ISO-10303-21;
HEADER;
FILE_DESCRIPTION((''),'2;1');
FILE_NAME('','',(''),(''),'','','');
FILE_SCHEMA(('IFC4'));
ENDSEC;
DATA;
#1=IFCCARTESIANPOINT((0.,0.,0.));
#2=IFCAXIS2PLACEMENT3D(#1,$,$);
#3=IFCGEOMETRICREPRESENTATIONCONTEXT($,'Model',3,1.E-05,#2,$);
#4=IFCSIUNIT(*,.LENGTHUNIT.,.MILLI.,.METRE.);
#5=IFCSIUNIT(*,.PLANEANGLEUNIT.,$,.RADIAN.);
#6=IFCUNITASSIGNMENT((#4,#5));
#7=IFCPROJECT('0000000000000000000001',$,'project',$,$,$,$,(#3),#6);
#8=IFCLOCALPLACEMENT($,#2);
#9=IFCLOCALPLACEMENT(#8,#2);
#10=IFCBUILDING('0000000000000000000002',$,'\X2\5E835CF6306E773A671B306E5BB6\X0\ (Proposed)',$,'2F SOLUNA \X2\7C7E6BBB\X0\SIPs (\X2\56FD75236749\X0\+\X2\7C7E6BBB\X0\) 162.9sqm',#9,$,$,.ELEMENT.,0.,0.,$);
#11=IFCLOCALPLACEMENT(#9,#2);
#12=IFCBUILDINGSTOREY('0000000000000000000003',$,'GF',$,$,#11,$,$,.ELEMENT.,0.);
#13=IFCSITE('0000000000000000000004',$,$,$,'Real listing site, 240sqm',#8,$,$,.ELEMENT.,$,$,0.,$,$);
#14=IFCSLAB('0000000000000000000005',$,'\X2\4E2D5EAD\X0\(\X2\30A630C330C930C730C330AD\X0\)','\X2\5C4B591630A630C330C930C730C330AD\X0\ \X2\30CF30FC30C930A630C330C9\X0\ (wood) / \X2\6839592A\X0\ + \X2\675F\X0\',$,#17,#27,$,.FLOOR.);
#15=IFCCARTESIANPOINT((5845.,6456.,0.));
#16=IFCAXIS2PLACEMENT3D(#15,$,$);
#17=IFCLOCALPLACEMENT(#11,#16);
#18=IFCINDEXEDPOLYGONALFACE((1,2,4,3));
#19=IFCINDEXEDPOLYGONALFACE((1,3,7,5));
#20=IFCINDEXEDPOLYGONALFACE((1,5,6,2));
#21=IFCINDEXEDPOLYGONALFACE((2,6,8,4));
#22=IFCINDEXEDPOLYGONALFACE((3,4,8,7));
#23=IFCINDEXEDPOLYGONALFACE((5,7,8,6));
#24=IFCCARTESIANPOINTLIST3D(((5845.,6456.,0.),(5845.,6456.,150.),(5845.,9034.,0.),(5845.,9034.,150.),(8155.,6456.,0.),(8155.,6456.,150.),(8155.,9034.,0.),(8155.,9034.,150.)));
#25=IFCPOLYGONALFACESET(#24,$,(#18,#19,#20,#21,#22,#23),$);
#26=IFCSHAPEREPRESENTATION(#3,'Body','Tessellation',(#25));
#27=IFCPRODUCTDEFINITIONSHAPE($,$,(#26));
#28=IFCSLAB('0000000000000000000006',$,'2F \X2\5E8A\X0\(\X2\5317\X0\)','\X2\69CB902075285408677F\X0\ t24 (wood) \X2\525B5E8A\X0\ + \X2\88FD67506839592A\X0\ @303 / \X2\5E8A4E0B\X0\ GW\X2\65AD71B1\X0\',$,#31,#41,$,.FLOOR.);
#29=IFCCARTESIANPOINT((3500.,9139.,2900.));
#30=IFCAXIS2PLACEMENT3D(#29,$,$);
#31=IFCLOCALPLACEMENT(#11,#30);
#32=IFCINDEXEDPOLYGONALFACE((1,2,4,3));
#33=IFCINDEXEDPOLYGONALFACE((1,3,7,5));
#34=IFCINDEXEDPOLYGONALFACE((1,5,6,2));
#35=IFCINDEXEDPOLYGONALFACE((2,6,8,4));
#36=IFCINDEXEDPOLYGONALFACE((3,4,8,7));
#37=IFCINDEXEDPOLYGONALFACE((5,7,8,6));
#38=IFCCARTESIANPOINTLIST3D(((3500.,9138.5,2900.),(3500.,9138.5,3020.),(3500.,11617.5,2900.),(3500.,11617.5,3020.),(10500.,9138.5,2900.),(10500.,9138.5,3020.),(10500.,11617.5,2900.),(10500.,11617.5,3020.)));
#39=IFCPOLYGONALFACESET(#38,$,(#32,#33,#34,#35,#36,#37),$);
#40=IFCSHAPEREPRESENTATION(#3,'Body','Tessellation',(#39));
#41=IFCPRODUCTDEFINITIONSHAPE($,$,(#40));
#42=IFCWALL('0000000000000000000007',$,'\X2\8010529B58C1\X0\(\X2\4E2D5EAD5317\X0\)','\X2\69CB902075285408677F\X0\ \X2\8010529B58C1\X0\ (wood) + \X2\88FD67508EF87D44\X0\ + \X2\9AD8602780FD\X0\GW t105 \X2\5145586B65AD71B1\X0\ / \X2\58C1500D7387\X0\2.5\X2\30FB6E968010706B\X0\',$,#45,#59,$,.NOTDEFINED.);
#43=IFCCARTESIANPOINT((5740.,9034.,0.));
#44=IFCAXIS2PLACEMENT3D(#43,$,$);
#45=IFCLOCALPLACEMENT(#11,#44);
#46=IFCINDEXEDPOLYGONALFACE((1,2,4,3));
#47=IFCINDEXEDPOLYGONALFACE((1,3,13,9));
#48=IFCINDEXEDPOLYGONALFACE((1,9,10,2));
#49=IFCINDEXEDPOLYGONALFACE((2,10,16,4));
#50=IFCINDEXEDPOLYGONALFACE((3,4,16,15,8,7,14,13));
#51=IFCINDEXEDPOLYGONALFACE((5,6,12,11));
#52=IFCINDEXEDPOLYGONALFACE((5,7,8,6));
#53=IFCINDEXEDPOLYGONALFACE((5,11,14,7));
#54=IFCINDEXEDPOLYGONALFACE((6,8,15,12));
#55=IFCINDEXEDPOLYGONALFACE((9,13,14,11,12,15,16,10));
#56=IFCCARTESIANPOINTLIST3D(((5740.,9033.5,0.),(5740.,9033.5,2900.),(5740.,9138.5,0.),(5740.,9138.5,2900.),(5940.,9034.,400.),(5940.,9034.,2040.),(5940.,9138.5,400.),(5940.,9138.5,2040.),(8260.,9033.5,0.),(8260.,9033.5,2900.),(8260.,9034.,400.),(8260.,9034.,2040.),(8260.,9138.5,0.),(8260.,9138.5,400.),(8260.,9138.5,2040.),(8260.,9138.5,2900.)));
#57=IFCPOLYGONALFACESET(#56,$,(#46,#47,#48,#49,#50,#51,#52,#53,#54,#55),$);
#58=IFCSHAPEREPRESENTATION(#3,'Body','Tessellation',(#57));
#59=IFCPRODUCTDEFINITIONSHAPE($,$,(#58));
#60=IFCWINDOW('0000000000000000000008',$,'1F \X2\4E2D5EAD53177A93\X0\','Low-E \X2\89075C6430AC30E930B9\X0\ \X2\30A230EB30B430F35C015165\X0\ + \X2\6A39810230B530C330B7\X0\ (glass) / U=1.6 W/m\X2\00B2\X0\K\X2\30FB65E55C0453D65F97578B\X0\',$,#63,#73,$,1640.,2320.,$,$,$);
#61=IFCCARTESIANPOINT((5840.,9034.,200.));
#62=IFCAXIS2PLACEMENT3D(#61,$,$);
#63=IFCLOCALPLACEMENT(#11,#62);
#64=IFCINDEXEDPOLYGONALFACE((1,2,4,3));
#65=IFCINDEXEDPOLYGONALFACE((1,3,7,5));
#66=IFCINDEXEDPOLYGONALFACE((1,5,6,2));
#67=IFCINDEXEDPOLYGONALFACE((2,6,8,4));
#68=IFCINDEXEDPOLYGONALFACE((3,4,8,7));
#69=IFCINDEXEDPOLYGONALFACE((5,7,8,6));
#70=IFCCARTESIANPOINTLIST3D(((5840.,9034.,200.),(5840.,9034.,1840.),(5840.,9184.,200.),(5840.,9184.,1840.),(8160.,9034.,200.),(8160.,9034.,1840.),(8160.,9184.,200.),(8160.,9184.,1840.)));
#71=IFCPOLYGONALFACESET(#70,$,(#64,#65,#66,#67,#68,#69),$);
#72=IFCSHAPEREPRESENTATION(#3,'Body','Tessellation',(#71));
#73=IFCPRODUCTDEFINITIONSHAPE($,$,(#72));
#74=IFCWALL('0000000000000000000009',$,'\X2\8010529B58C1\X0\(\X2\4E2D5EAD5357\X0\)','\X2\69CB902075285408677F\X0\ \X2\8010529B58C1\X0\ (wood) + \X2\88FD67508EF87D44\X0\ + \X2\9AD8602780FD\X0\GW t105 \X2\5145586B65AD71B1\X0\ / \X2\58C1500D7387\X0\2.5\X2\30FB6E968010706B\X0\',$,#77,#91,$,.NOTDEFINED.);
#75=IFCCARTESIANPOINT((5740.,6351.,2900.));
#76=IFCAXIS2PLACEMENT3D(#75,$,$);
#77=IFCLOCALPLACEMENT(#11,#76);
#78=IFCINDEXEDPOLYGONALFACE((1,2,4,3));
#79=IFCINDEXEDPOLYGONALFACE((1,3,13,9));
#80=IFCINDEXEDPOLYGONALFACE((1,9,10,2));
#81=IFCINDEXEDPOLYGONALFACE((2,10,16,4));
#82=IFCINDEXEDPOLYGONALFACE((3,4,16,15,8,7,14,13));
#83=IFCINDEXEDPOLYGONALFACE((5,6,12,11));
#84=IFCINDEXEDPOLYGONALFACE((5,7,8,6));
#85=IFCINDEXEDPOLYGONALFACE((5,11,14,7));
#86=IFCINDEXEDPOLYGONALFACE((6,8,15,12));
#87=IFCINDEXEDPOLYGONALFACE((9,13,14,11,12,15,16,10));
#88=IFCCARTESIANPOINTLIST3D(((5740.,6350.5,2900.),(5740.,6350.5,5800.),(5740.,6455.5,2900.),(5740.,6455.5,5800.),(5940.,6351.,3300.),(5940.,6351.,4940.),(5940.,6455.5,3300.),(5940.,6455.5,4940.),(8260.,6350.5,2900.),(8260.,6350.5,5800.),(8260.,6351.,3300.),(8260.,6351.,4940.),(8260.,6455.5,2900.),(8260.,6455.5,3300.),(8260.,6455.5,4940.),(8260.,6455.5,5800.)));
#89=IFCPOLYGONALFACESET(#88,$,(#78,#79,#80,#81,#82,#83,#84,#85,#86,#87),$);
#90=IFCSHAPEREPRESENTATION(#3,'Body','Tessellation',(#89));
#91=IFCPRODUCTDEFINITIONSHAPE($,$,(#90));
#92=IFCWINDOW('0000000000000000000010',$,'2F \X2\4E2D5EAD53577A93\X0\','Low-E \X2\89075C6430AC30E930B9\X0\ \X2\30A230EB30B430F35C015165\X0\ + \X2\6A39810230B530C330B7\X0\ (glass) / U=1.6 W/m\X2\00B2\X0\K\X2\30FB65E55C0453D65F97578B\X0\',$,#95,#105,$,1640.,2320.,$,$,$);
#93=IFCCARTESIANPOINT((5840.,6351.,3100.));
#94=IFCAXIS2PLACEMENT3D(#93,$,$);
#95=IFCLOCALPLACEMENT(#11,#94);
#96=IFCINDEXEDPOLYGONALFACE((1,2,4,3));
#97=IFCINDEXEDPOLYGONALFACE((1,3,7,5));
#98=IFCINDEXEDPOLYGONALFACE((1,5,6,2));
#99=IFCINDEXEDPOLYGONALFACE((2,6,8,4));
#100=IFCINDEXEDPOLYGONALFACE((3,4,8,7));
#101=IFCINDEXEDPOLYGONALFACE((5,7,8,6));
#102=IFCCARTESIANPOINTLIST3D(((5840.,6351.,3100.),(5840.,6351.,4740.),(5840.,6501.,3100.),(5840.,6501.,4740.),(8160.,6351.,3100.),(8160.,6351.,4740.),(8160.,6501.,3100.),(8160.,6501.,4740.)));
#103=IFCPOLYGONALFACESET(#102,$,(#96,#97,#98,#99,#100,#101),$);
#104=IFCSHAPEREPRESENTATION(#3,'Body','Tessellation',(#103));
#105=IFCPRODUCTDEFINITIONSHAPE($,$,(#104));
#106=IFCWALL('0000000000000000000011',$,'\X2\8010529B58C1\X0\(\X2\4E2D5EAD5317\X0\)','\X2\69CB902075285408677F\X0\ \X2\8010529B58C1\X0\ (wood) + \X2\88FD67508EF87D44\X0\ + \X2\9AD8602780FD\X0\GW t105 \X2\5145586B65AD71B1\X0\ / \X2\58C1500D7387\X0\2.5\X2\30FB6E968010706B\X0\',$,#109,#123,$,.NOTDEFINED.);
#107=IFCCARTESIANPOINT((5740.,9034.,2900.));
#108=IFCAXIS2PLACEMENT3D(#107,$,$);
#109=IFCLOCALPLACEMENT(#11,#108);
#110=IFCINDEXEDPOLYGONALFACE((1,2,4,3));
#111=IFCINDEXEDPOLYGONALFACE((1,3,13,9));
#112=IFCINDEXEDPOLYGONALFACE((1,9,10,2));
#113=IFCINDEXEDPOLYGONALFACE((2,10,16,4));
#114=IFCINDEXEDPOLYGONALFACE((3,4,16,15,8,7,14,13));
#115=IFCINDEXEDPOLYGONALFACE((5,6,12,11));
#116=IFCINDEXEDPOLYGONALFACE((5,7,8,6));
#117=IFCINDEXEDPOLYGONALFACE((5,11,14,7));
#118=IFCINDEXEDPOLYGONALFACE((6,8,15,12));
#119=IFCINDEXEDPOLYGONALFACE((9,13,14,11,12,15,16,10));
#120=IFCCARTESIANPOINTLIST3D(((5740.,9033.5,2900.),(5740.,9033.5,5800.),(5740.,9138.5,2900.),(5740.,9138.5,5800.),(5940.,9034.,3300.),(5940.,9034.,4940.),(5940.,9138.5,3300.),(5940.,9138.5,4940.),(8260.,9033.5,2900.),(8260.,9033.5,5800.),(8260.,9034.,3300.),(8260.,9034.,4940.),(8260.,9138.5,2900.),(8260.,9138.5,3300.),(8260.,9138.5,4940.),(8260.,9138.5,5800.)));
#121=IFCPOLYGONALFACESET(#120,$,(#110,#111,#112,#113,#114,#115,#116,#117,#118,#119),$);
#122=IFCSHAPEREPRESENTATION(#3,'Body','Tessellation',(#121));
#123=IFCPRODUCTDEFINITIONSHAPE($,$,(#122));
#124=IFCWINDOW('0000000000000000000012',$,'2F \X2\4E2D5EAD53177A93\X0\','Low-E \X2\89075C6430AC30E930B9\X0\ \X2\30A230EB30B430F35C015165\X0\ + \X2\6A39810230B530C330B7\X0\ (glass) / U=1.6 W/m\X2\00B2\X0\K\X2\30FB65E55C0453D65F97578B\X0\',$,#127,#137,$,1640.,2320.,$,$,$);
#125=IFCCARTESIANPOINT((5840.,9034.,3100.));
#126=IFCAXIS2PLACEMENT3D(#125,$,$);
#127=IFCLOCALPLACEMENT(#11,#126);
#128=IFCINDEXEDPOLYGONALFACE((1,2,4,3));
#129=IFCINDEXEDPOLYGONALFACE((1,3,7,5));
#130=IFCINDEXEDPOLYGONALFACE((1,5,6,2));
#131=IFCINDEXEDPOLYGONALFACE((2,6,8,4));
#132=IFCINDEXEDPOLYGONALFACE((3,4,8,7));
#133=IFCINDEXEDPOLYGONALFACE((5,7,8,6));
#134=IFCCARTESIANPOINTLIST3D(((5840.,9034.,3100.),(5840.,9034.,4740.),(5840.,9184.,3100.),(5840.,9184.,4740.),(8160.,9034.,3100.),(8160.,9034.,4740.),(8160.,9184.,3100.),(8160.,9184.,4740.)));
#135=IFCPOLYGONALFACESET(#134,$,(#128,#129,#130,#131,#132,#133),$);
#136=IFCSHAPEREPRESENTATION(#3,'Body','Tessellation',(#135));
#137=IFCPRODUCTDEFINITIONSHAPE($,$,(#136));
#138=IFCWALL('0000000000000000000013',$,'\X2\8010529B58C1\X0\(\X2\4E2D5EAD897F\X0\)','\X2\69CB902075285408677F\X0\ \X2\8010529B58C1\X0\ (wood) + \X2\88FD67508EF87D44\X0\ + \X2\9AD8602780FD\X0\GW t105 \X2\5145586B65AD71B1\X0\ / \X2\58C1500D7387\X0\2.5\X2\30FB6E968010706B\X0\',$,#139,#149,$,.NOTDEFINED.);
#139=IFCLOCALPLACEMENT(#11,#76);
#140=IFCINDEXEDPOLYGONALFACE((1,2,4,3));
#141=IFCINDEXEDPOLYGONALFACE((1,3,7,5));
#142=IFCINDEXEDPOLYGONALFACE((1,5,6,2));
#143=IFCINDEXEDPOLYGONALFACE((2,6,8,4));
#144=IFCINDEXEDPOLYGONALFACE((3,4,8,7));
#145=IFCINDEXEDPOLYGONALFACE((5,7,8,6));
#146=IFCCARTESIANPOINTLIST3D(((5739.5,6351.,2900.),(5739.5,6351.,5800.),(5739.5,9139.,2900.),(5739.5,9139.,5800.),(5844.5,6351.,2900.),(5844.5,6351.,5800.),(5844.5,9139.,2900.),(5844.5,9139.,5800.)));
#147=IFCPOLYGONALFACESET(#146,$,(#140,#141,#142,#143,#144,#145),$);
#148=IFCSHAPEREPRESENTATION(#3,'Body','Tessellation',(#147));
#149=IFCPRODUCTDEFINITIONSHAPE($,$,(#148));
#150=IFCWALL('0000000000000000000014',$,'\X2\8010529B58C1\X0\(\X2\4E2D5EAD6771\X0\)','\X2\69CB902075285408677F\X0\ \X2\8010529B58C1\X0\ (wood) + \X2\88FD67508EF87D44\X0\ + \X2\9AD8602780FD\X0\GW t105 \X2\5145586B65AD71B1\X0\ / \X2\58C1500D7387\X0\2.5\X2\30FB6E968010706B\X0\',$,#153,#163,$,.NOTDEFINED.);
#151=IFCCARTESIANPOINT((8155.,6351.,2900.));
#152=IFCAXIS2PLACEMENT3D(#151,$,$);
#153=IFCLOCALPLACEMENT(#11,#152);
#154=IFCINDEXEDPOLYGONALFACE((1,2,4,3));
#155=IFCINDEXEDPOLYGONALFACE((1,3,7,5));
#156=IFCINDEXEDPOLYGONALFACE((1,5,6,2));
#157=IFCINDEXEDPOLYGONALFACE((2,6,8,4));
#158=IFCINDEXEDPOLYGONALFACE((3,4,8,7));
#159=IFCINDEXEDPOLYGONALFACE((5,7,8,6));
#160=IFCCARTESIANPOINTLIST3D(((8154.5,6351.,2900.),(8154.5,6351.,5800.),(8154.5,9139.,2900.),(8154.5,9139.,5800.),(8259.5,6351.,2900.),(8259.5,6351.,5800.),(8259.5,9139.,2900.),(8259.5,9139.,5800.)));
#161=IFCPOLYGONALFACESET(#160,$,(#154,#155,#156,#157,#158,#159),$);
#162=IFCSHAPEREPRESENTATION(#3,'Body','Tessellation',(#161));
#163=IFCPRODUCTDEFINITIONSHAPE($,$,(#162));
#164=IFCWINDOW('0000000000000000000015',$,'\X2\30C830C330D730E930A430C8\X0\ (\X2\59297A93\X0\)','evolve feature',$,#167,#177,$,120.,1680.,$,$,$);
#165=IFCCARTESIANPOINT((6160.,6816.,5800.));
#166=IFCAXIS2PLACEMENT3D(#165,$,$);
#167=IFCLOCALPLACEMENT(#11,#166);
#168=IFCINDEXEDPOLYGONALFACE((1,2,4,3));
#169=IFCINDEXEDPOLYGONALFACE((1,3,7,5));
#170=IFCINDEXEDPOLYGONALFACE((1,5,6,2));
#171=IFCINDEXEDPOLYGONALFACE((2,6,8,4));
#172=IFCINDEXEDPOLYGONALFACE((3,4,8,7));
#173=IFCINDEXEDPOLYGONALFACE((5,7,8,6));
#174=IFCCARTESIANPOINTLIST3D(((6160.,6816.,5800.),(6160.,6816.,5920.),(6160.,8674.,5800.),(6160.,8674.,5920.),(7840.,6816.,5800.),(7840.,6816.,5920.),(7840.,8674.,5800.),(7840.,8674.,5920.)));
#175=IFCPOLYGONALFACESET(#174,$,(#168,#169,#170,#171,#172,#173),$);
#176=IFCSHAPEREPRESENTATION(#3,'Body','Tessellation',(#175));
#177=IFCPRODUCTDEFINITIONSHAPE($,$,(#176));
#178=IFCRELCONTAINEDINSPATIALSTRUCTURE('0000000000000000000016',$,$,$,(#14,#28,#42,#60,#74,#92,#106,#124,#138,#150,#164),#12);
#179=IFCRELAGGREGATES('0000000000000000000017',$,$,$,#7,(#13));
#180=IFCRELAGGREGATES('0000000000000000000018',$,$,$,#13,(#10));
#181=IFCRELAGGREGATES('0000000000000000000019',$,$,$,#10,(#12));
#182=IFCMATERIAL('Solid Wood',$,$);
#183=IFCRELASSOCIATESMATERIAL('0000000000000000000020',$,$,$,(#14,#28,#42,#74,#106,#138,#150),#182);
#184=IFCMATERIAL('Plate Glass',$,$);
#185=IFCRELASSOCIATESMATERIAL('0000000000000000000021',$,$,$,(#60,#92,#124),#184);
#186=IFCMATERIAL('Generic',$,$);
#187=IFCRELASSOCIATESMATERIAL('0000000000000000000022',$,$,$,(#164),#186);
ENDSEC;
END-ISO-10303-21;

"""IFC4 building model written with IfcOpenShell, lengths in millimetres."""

from ifc_helpers import new_model, si_unit, frame, frame_2d, origin, place, context, project, spatial, rectangle, extrude, material, element, fill, save


model = new_model("IFC4")

# Units and contexts
model_context = context("Model", 3, precision=1e-05, world=origin())
ifc_project = project(units=[si_unit("LENGTHUNIT", "METRE", prefix="MILLI"), si_unit("PLANEANGLEUNIT", "RADIAN")], contexts=[model_context])

# Site, building, storey
site_placement = place(None, origin())
site = spatial("IfcSite", under=ifc_project, at=site_placement, ObjectType="Real listing site, 240sqm", CompositionType="ELEMENT", RefElevation=0.0)
building_placement = place(site_placement, origin())
building = spatial("IfcBuilding", under=site, at=building_placement, Name="広島の眺望の家 (Proposed)", ObjectType="2F SOLUNA 籾殻SIPs (国産杉+籾殻) 162.9sqm", CompositionType="ELEMENT", ElevationOfRefHeight=0.0, ElevationOfTerrain=0.0)
storey_placement = place(building_placement, origin())
storey = spatial("IfcBuildingStorey", under=building, at=storey_placement, Name="GF", CompositionType="ELEMENT", Elevation=0.0)

# Slabs
ifc_material_1 = material(Name="Solid Wood")
slab_1_placement = place(storey_placement, frame((5845.0, 6456.0, 0.0)))
element("IfcSlab", 1, at=slab_1_placement, inside=storey, material=ifc_material_1, Name="中庭(ウッドデッキ)", Description="屋外ウッドデッキ ハードウッド (wood) / 根太 + 束", PredefinedType="FLOOR", context=model_context, shape_type="SweptSolid", body=[
    extrude(rectangle(XDim=2310.0, YDim=2578.0, at=frame_2d((1155.0, 1289.0))), frame((5845.0, 6456.0, 0.0)), (0.0, 0.0, 1.0), 150.0),
])
slab_2_placement = place(storey_placement, frame((3500.0, 9139.0, 2900.0)))
element("IfcSlab", 2, at=slab_2_placement, inside=storey, material=ifc_material_1, Name="2F 床(北)", Description="構造用合板 t24 (wood) 剛床 + 製材根太 @303 / 床下 GW断熱", PredefinedType="FLOOR", context=model_context, shape_type="SweptSolid", body=[
    extrude(rectangle(XDim=7000.0, YDim=2479.0, at=frame_2d((3500.0, 1239.0))), frame((3500.0, 9139.0, 2900.0)), (0.0, 0.0, 1.0), 120.0),
])
ifc_material_2 = material(Name="Generic")

# Wall, opening, window
wall_1_placement = place(storey_placement, frame((5740.0, 9034.0, 0.0)))
wall_1 = element("IfcWall", 3, at=wall_1_placement, inside=storey, material=ifc_material_1, Name="耐力壁(中庭北)", Description="構造用合板 耐力壁 (wood) + 製材軸組 + 高性能GW t105 充填断熱 / 壁倍率2.5・準耐火", PredefinedType="NOTDEFINED", context=model_context, shape_type="SweptSolid", body=[
    extrude(rectangle(XDim=2520.0, YDim=105.0, at=frame_2d((1260.0, 52.0))), frame((5740.0, 9034.0, 0.0)), (0.0, 0.0, 1.0), 2900.0),
])
opening_1_placement = place(storey_placement, frame((5840.0, 9034.0, 200.0)))
opening_1 = element("IfcOpeningElement", 4, at=opening_1_placement, cuts=wall_1, PredefinedType="NOTDEFINED", context=model_context, shape_type="SweptSolid", body=[
    extrude(rectangle(XDim=2320.0, YDim=150.0, at=frame_2d((1160.0, 75.0))), frame((5840.0, 9034.0, 200.0)), (0.0, 0.0, 1.0), 1640.0),
])
ifc_material_3 = material(Name="Plate Glass")
window_1_placement = place(storey_placement, frame((5840.0, 9034.0, 200.0)))
window_1 = element("IfcWindow", 5, at=window_1_placement, inside=storey, material=ifc_material_3, Name="1F 中庭北窓", Description="Low-E 複層ガラス アルゴン封入 + 樹脂サッシ (glass) / U=1.6 W/m²K・日射取得型", OverallHeight=1640.0, OverallWidth=2320.0, context=model_context, shape_type="SweptSolid", body=[
    extrude(rectangle(XDim=2320.0, YDim=150.0, at=frame_2d((1160.0, 75.0))), frame((5840.0, 9034.0, 200.0)), (0.0, 0.0, 1.0), 1640.0),
])
fill(opening_1, window_1)

# Walls, openings, windows
wall_2_placement = place(storey_placement, frame((5740.0, 6351.0, 2900.0)))
wall_2 = element("IfcWall", 6, at=wall_2_placement, inside=storey, material=ifc_material_1, Name="耐力壁(中庭南)", Description="構造用合板 耐力壁 (wood) + 製材軸組 + 高性能GW t105 充填断熱 / 壁倍率2.5・準耐火", PredefinedType="NOTDEFINED", context=model_context, shape_type="SweptSolid", body=[
    extrude(rectangle(XDim=2520.0, YDim=105.0, at=frame_2d((1260.0, 52.0))), frame((5740.0, 6351.0, 2900.0)), (0.0, 0.0, 1.0), 2900.0),
])
opening_2_placement = place(storey_placement, frame((5840.0, 6351.0, 3100.0)))
opening_2 = element("IfcOpeningElement", 7, at=opening_2_placement, cuts=wall_2, PredefinedType="NOTDEFINED", context=model_context, shape_type="SweptSolid", body=[
    extrude(rectangle(XDim=2320.0, YDim=150.0, at=frame_2d((1160.0, 75.0))), frame((5840.0, 6351.0, 3100.0)), (0.0, 0.0, 1.0), 1640.0),
])
window_2_placement = place(storey_placement, frame((5840.0, 6351.0, 3100.0)))
window_2 = element("IfcWindow", 8, at=window_2_placement, inside=storey, material=ifc_material_3, Name="2F 中庭南窓", Description="Low-E 複層ガラス アルゴン封入 + 樹脂サッシ (glass) / U=1.6 W/m²K・日射取得型", OverallHeight=1640.0, OverallWidth=2320.0, context=model_context, shape_type="SweptSolid", body=[
    extrude(rectangle(XDim=2320.0, YDim=150.0, at=frame_2d((1160.0, 75.0))), frame((5840.0, 6351.0, 3100.0)), (0.0, 0.0, 1.0), 1640.0),
])
fill(opening_2, window_2)
wall_3_placement = place(storey_placement, frame((5740.0, 9034.0, 2900.0)))
wall_3 = element("IfcWall", 9, at=wall_3_placement, inside=storey, material=ifc_material_1, Name="耐力壁(中庭北)", Description="構造用合板 耐力壁 (wood) + 製材軸組 + 高性能GW t105 充填断熱 / 壁倍率2.5・準耐火", PredefinedType="NOTDEFINED", context=model_context, shape_type="SweptSolid", body=[
    extrude(rectangle(XDim=2520.0, YDim=105.0, at=frame_2d((1260.0, 52.0))), frame((5740.0, 9034.0, 2900.0)), (0.0, 0.0, 1.0), 2900.0),
])
opening_3_placement = place(storey_placement, frame((5840.0, 9034.0, 3100.0)))
opening_3 = element("IfcOpeningElement", 10, at=opening_3_placement, cuts=wall_3, PredefinedType="NOTDEFINED", context=model_context, shape_type="SweptSolid", body=[
    extrude(rectangle(XDim=2320.0, YDim=150.0, at=frame_2d((1160.0, 75.0))), frame((5840.0, 9034.0, 3100.0)), (0.0, 0.0, 1.0), 1640.0),
])
window_3_placement = place(storey_placement, frame((5840.0, 9034.0, 3100.0)))
window_3 = element("IfcWindow", 11, at=window_3_placement, inside=storey, material=ifc_material_3, Name="2F 中庭北窓", Description="Low-E 複層ガラス アルゴン封入 + 樹脂サッシ (glass) / U=1.6 W/m²K・日射取得型", OverallHeight=1640.0, OverallWidth=2320.0, context=model_context, shape_type="SweptSolid", body=[
    extrude(rectangle(XDim=2320.0, YDim=150.0, at=frame_2d((1160.0, 75.0))), frame((5840.0, 9034.0, 3100.0)), (0.0, 0.0, 1.0), 1640.0),
])
fill(opening_3, window_3)

# Walls
wall_4_placement = place(storey_placement, frame((5740.0, 6351.0, 2900.0)))
element("IfcWall", 12, at=wall_4_placement, inside=storey, material=ifc_material_1, Name="耐力壁(中庭西)", Description="構造用合板 耐力壁 (wood) + 製材軸組 + 高性能GW t105 充填断熱 / 壁倍率2.5・準耐火", PredefinedType="NOTDEFINED", context=model_context, shape_type="SweptSolid", body=[
    extrude(rectangle(XDim=105.0, YDim=2788.0, at=frame_2d((52.0, 1394.0))), frame((5740.0, 6351.0, 2900.0)), (0.0, 0.0, 1.0), 2900.0),
])
wall_5_placement = place(storey_placement, frame((8155.0, 6351.0, 2900.0)))
element("IfcWall", 13, at=wall_5_placement, inside=storey, material=ifc_material_1, Name="耐力壁(中庭東)", Description="構造用合板 耐力壁 (wood) + 製材軸組 + 高性能GW t105 充填断熱 / 壁倍率2.5・準耐火", PredefinedType="NOTDEFINED", context=model_context, shape_type="SweptSolid", body=[
    extrude(rectangle(XDim=105.0, YDim=2788.0, at=frame_2d((52.0, 1394.0))), frame((8155.0, 6351.0, 2900.0)), (0.0, 0.0, 1.0), 2900.0),
])

# Window
window_4_placement = place(storey_placement, frame((6160.0, 6816.0, 5800.0)))
element("IfcWindow", 14, at=window_4_placement, inside=storey, material=ifc_material_2, Name="トップライト (天窓)", Description="evolve feature", OverallHeight=120.0, OverallWidth=1680.0, context=model_context, shape_type="SweptSolid", body=[
    extrude(rectangle(XDim=1680.0, YDim=1858.0, at=frame_2d((840.0, 929.0))), frame((6160.0, 6816.0, 5800.0)), (0.0, 0.0, 1.0), 120.0),
])

save(model, "model.ifc")
